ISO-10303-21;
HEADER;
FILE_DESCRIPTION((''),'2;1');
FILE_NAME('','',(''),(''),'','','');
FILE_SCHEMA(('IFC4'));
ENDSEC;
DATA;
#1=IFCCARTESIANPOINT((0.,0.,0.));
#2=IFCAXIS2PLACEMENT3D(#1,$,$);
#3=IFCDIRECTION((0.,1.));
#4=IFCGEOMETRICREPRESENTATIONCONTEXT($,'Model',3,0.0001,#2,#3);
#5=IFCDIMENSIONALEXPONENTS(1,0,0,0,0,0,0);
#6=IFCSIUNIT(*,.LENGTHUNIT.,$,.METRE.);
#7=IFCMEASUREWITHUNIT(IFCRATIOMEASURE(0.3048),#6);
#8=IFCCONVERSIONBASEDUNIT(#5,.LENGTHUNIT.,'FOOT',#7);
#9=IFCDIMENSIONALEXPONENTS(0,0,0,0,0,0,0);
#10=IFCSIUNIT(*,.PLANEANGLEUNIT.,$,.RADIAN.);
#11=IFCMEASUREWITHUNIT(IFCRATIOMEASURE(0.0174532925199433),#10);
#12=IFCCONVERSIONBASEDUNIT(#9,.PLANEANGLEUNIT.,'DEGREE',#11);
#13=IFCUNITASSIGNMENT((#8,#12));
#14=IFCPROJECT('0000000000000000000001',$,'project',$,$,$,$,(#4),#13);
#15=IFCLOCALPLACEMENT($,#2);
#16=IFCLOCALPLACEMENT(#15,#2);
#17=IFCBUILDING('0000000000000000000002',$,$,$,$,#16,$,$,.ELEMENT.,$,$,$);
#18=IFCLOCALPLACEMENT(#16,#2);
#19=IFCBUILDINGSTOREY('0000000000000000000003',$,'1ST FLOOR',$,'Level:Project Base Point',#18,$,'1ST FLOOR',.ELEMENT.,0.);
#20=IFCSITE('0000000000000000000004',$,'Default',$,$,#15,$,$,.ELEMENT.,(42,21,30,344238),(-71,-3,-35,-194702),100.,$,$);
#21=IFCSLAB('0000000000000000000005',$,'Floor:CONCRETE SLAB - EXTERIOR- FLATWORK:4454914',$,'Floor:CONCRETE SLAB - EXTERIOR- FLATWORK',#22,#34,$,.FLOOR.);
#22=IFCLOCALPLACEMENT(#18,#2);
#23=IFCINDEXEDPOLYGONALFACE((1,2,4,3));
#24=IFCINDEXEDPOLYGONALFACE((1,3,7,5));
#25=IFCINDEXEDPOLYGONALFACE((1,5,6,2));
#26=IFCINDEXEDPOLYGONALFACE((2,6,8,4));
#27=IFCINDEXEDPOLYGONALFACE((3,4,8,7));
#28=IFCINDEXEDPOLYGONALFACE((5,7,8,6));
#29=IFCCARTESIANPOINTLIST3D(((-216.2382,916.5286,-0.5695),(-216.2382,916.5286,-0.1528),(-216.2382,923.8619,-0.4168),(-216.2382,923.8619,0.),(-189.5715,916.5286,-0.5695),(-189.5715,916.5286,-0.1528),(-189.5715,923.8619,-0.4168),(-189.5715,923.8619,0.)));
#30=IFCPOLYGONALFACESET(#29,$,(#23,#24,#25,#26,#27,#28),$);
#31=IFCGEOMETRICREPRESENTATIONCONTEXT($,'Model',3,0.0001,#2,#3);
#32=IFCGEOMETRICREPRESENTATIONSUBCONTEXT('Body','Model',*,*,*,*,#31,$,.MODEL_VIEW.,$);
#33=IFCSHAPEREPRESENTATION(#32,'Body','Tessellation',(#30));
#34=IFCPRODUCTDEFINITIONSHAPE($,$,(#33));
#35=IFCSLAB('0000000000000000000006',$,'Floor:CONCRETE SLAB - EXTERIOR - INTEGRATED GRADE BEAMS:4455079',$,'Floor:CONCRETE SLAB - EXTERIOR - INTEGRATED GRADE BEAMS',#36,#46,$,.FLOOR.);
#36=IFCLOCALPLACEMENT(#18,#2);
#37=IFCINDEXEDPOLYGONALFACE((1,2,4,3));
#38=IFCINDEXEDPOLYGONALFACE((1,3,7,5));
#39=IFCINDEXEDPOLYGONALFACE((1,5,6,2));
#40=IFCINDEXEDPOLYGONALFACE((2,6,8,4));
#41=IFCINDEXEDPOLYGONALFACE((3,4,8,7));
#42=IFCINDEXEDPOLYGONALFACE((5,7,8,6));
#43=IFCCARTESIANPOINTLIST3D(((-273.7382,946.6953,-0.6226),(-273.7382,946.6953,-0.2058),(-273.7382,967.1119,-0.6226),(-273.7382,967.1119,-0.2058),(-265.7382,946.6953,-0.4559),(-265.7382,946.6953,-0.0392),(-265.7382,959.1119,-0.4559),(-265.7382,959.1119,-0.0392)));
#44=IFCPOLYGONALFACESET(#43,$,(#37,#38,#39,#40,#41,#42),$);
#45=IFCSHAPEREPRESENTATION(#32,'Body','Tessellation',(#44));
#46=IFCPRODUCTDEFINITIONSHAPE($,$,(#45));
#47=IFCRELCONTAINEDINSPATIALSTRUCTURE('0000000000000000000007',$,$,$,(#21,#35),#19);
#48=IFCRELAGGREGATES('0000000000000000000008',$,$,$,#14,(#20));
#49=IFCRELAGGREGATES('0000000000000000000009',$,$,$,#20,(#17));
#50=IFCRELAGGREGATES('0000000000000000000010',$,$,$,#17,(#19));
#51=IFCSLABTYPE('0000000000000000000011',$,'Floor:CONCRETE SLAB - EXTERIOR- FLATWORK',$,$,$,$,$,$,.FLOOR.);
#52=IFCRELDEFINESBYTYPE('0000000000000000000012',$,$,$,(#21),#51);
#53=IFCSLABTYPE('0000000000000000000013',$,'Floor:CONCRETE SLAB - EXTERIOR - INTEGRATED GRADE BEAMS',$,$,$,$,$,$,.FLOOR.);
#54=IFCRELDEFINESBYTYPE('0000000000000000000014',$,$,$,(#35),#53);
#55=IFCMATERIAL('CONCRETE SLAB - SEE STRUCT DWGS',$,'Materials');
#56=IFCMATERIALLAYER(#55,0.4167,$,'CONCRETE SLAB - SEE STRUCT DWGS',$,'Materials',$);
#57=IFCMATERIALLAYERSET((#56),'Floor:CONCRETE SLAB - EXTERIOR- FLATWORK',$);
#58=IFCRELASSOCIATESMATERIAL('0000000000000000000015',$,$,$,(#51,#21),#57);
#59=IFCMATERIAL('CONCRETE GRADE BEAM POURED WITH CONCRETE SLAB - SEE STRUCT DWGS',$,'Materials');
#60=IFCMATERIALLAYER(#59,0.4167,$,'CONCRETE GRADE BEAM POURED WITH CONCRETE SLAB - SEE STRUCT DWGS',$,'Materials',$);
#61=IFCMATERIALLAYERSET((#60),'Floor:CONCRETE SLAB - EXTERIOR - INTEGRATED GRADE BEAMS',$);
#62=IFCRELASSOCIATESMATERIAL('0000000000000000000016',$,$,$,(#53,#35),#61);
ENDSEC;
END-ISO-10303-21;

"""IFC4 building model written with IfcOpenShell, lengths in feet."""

from ifc_helpers import new_model, entity, si_unit, converted_unit, direction, frame, frame_2d, origin, place, context, subcontext, project, spatial, polyline, rectangle, outline, extrude, clip, halfspace, material, layer, layer_set, layer_usage, type_object, element, save


model = new_model("IFC4")

# Units and contexts
model_context_1 = context("Model", 3, precision=0.0001, world=origin(), true_north=direction((0.0, 1.0)))
model_context_2 = context("Model", 3, precision=0.0001, world=origin(), true_north=direction((0.0, 1.0)))
body_context = subcontext(model_context_2, "Body", "Model", "MODEL_VIEW")
ifc_project = project(units=[converted_unit("LENGTHUNIT", "FOOT", entity("IfcRatioMeasure", 0.3048), si_unit("LENGTHUNIT", "METRE"), dimensions=[1, 0, 0, 0, 0, 0, 0]), converted_unit("PLANEANGLEUNIT", "DEGREE", entity("IfcRatioMeasure", 0.0174532925199433), si_unit("PLANEANGLEUNIT", "RADIAN"), dimensions=[0, 0, 0, 0, 0, 0, 0])], contexts=[model_context_1])

# Site, building, storey
site_placement = place(None, origin())
site = spatial("IfcSite", under=ifc_project, at=site_placement, Name="Default", CompositionType="ELEMENT", RefLatitude=(42, 21, 30, 344238), RefLongitude=(-71, -3, -35, -194702), RefElevation=100.0)
building_placement = place(site_placement, origin())
building = spatial("IfcBuilding", under=site, at=building_placement, CompositionType="ELEMENT")
storey_placement = place(building_placement, origin())
storey = spatial("IfcBuildingStorey", under=building, at=storey_placement, Name="1ST FLOOR", ObjectType="Level:Project Base Point", LongName="1ST FLOOR", CompositionType="ELEMENT", Elevation=0.0)

# Slabs
ifc_material_1 = material(Name="CONCRETE SLAB - SEE STRUCT DWGS", Category="Materials")
ifc_layer_1 = layer(ifc_material_1, 0.4167, Name="CONCRETE SLAB - SEE STRUCT DWGS", Category="Materials")
ifc_layer_set_1 = layer_set([ifc_layer_1], Name="Floor:CONCRETE SLAB - EXTERIOR- FLATWORK")
ifc_layer_usage_1 = layer_usage(ifc_layer_set_1, "AXIS3", "POSITIVE", 0.0)
slab_type_1 = type_object("IfcSlabType", Name="Floor:CONCRETE SLAB - EXTERIOR- FLATWORK", PredefinedType="FLOOR", material=ifc_layer_set_1)
slab_1_placement = place(storey_placement, origin())
element("IfcSlab", 1, at=slab_1_placement, inside=storey, type_object=slab_type_1, material=ifc_layer_usage_1, Name="Floor:CONCRETE SLAB - EXTERIOR- FLATWORK:4454914", ObjectType="Floor:CONCRETE SLAB - EXTERIOR- FLATWORK", PredefinedType="FLOOR", context=body_context, shape_type="Clipping", body=[
    clip(clip(extrude(rectangle(XDim=7.3349, YDim=26.6667, at=frame_2d((0.0, 0.0), x_axis=(1.0, 0.0))), frame((-202.9048, 920.1953, -0.0764), z_axis=(0.0, 0.020829, -0.999783), x_axis=(0.0, 0.999783, 0.020829)), (-0.020829, 0.0, 0.999783), 0.4168), halfspace(frame((-216.2382, 923.8619, -0.4168), z_axis=(0.0, 0.020829, -0.999783), x_axis=(0.0, 0.999783, 0.020829)), False)), halfspace(frame((-216.2382, 923.8619, 0.0), z_axis=(0.0, -0.020829, 0.999783), x_axis=(0.0, -0.999783, -0.020829)), False)),
])
ifc_material_2 = material(Name="CONCRETE GRADE BEAM POURED WITH CONCRETE SLAB - SEE STRUCT DWGS", Category="Materials")
ifc_layer_2 = layer(ifc_material_2, 0.4167, Name="CONCRETE GRADE BEAM POURED WITH CONCRETE SLAB - SEE STRUCT DWGS", Category="Materials")
ifc_layer_set_2 = layer_set([ifc_layer_2], Name="Floor:CONCRETE SLAB - EXTERIOR - INTEGRATED GRADE BEAMS")
ifc_layer_usage_2 = layer_usage(ifc_layer_set_2, "AXIS3", "POSITIVE", 0.0)
slab_type_2 = type_object("IfcSlabType", Name="Floor:CONCRETE SLAB - EXTERIOR - INTEGRATED GRADE BEAMS", PredefinedType="FLOOR", material=ifc_layer_set_2)
slab_2_placement = place(storey_placement, origin())
element("IfcSlab", 2, at=slab_2_placement, inside=storey, type_object=slab_type_2, material=ifc_layer_usage_2, Name="Floor:CONCRETE SLAB - EXTERIOR - INTEGRATED GRADE BEAMS:4455079", ObjectType="Floor:CONCRETE SLAB - EXTERIOR - INTEGRATED GRADE BEAMS", PredefinedType="FLOOR", context=body_context, shape_type="Clipping", body=[
    clip(clip(extrude(outline(polyline([(-8.2083, -4.0009), (12.2083, -4.0009), (4.2083, 4.0009), (-8.2083, 4.0009), (-8.2083, -4.0009)])), frame((-269.7382, 954.9036, -0.1225), z_axis=(0.020829, 0.0, -0.999783), x_axis=(0.0, 1.0, 0.0)), (0.0, -0.020829, 0.999783), 0.4168), halfspace(frame((-265.7382, 959.1119, -0.4559), z_axis=(0.020829, 0.0, -0.999783), x_axis=(0.999783, 0.0, 0.020829)), False)), halfspace(frame((-265.7382, 959.1119, -0.0392), z_axis=(-0.020829, 0.0, 0.999783), x_axis=(-0.999783, 0.0, -0.020829)), False)),
])

save(model, "model.ifc")
